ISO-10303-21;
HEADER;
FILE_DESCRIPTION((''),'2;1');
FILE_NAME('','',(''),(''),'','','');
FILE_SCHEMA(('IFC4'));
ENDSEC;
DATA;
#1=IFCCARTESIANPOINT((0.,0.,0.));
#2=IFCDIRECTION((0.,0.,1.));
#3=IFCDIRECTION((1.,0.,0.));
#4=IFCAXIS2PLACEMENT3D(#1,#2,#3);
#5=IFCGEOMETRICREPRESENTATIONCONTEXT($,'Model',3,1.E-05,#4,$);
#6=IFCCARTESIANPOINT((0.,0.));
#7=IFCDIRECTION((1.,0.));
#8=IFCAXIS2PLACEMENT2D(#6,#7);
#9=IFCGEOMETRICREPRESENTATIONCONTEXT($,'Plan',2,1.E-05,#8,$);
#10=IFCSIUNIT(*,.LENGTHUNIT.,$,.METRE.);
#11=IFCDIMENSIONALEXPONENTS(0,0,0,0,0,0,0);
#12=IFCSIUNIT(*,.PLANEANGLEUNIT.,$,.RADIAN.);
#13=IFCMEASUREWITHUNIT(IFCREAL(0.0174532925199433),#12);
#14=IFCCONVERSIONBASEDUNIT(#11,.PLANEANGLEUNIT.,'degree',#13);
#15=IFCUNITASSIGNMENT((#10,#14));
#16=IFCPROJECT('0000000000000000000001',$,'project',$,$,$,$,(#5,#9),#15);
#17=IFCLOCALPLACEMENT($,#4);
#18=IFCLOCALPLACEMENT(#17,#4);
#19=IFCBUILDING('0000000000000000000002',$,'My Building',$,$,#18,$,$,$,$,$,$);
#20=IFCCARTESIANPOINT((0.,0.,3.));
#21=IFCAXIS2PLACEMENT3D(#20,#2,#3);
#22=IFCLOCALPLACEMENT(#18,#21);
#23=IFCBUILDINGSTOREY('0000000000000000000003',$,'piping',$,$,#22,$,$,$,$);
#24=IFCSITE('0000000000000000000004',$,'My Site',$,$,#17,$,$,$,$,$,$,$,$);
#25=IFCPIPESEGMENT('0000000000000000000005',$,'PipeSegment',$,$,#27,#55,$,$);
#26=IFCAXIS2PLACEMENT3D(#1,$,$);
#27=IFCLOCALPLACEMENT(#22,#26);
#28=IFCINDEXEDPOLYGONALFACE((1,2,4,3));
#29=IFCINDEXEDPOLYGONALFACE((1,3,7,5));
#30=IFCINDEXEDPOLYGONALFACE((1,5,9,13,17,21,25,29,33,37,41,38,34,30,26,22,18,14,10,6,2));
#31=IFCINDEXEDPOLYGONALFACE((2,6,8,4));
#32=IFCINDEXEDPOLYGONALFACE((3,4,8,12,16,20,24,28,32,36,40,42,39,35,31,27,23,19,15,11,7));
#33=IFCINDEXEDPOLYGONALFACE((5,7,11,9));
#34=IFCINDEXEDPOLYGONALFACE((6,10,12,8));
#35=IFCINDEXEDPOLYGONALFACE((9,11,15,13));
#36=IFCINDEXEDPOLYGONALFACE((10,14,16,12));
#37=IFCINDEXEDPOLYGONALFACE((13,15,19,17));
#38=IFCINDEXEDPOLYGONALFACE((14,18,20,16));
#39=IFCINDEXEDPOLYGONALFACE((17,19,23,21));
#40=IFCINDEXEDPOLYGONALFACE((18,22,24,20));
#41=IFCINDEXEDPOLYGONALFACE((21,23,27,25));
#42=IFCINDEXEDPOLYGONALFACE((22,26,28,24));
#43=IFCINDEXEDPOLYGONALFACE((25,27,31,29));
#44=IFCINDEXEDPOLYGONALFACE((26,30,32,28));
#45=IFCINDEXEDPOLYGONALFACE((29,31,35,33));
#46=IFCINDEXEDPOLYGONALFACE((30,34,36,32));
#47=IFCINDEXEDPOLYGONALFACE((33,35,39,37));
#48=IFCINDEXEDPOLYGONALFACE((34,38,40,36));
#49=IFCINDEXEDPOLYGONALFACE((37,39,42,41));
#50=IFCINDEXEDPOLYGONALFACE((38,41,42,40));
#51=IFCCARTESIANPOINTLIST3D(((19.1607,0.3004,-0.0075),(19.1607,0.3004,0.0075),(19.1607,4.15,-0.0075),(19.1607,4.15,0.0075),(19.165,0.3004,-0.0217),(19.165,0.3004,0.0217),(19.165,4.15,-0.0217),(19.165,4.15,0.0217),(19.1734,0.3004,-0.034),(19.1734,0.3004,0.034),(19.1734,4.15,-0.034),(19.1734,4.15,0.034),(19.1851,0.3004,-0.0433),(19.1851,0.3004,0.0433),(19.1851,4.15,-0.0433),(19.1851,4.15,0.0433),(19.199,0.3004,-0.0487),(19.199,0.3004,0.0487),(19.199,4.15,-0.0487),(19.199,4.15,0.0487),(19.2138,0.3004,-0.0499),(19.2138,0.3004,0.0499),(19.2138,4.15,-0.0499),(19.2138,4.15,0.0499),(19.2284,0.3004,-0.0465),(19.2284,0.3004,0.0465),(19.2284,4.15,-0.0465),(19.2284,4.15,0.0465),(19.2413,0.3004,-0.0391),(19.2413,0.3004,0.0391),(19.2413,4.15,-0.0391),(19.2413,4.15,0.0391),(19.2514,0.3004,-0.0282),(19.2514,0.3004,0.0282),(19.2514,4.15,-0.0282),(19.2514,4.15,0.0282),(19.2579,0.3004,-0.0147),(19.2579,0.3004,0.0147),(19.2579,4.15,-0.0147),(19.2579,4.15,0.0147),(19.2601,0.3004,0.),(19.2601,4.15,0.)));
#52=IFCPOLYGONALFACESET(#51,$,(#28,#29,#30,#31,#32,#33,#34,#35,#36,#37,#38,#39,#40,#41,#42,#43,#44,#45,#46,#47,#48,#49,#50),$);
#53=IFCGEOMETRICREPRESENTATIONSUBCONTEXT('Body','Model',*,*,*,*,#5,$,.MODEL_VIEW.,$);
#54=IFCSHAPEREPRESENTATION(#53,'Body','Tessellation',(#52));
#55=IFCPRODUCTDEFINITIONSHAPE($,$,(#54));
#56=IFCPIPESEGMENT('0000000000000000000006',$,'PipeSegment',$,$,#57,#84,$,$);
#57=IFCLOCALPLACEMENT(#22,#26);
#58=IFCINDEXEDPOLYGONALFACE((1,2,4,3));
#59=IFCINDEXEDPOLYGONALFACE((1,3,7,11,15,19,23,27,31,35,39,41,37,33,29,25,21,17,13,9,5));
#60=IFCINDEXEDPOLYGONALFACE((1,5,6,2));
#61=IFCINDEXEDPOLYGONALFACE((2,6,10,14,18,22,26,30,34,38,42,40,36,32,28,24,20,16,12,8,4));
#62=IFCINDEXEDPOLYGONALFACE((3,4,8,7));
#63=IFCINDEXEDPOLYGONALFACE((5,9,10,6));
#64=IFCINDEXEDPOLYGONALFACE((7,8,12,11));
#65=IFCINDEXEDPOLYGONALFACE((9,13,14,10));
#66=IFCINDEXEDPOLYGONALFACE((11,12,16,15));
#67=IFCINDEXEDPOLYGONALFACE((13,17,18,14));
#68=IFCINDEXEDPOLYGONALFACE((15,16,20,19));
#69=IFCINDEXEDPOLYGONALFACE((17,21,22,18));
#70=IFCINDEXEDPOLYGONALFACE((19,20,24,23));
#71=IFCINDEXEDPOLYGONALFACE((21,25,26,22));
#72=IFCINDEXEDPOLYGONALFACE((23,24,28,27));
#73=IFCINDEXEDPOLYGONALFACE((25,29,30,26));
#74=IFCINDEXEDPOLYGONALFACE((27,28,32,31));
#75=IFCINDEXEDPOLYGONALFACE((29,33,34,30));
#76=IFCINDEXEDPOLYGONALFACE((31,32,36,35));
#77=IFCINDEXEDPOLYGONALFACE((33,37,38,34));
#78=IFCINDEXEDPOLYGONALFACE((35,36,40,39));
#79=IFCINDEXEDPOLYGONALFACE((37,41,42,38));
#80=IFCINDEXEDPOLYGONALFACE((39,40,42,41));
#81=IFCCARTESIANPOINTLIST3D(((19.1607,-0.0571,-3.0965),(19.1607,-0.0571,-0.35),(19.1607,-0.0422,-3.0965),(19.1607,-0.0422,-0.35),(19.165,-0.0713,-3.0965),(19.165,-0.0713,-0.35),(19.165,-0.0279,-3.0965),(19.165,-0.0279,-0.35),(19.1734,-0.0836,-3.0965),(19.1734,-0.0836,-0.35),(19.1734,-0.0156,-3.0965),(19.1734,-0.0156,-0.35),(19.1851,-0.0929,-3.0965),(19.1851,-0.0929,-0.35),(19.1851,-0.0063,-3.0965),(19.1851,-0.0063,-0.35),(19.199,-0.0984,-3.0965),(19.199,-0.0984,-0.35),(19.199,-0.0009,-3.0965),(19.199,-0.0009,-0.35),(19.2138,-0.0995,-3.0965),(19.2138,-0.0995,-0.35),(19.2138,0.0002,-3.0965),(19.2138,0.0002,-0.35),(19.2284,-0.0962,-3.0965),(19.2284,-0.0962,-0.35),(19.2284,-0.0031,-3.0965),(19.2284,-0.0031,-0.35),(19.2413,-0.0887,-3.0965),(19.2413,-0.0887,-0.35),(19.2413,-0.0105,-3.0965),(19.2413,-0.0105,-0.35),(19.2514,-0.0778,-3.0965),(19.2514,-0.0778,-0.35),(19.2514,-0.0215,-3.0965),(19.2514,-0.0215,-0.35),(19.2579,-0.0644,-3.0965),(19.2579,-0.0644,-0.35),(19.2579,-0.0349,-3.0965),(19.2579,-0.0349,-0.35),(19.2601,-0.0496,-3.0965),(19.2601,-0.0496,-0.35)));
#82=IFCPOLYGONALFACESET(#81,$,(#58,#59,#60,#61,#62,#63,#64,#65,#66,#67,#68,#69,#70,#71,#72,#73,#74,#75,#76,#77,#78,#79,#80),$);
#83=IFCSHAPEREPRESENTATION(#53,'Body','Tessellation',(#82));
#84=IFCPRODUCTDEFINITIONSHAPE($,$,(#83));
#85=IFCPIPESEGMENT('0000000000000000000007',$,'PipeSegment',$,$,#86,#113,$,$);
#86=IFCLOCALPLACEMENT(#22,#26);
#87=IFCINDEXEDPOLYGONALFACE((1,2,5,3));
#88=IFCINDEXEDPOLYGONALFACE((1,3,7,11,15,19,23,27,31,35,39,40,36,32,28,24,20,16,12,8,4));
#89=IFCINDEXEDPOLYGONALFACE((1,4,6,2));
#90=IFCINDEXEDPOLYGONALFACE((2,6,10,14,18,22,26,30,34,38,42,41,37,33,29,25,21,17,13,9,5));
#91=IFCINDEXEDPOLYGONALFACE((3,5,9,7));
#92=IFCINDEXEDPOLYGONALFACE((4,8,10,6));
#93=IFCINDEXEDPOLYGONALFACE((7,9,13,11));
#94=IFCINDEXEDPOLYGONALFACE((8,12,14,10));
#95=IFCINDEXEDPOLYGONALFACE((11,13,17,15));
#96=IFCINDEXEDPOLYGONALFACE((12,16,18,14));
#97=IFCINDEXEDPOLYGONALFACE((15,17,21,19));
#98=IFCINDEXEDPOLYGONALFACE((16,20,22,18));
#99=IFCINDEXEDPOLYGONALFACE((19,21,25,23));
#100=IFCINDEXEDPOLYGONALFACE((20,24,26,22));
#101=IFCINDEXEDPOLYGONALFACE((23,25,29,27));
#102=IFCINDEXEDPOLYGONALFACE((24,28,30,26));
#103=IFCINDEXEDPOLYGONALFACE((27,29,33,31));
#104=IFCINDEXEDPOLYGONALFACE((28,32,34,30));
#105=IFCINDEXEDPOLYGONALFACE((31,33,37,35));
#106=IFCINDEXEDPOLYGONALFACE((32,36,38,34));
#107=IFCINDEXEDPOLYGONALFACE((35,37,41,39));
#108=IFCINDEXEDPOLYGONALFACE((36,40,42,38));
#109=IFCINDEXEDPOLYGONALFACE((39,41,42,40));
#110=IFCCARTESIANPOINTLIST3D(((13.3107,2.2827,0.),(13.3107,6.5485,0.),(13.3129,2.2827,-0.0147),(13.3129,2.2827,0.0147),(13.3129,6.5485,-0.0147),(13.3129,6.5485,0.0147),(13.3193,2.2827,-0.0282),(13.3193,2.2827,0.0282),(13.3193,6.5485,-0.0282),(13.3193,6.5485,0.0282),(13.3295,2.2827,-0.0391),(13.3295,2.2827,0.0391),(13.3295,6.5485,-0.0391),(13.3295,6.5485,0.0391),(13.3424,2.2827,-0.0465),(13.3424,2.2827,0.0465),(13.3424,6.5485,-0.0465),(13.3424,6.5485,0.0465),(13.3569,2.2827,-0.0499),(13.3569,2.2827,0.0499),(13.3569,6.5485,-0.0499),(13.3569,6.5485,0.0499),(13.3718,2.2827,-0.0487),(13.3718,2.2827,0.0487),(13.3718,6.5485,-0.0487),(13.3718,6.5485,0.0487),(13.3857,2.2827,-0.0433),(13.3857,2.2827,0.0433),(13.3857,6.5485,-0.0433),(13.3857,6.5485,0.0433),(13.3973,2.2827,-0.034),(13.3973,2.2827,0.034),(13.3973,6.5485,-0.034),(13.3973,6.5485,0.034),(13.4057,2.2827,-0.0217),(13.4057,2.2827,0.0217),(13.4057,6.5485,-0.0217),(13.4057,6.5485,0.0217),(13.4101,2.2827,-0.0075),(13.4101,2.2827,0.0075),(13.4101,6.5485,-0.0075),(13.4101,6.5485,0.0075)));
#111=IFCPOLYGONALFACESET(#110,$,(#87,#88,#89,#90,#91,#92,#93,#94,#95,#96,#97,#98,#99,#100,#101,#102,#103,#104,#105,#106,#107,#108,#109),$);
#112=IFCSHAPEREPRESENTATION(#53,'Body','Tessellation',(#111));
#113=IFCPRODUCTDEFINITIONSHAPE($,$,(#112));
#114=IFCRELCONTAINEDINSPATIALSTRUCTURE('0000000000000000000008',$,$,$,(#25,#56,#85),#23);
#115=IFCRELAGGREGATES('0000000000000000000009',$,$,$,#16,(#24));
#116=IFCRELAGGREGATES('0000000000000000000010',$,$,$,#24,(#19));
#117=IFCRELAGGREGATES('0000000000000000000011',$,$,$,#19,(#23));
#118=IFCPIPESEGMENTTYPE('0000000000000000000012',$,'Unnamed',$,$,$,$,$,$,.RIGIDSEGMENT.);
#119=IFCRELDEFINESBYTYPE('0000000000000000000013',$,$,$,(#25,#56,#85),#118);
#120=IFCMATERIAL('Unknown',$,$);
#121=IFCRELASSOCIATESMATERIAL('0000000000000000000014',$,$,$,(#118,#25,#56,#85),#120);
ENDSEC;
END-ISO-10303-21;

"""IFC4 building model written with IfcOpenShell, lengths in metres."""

from ifc_helpers import new_model, entity, si_unit, converted_unit, frame, origin_with_axes, origin_2d_with_axis, place, context, subcontext, project, spatial, circle, extrude, material, material_profile, profile_set, profile_usage, type_object, element, save


model = new_model("IFC4")

# Units and contexts
model_context = context("Model", 3, precision=1e-05, world=origin_with_axes())
plan_context = context("Plan", 2, precision=1e-05, world=origin_2d_with_axis())
body_context = subcontext(model_context, "Body", "Model", "MODEL_VIEW")
ifc_project = project(units=[si_unit("LENGTHUNIT", "METRE"), converted_unit("PLANEANGLEUNIT", "degree", entity("IfcReal", 0.0174532925199433), si_unit("PLANEANGLEUNIT", "RADIAN"), dimensions=[0, 0, 0, 0, 0, 0, 0])], contexts=[model_context, plan_context])

# Site, building, storey
site_placement = place(None, origin_with_axes())
site = spatial("IfcSite", under=ifc_project, at=site_placement, Name="My Site")
building_placement = place(site_placement, origin_with_axes())
building = spatial("IfcBuilding", under=site, at=building_placement, Name="My Building")
storey_placement = place(building_placement, frame((0.0, 0.0, 3.0), z_axis=(0.0, 0.0, 1.0), x_axis=(1.0, 0.0, 0.0)))
storey = spatial("IfcBuildingStorey", under=building, at=storey_placement, Name="piping")

# Pipe segments
ifc_material = material(Name="Unknown")
ifc_material_profile = material_profile(ifc_material, circle(Radius=0.05))
ifc_profile_set = profile_set([ifc_material_profile])
pipe_segment_type = type_object("IfcPipeSegmentType", Name="Unnamed", PredefinedType="RIGIDSEGMENT", material=ifc_profile_set)
ifc_profile_usage_1 = profile_usage(ifc_profile_set, cardinal=5)
pipe_segment_1_placement = place(storey_placement, frame((19.2101, 4.15, 0.0), z_axis=(0.0, -1.0, 0.0), x_axis=(1.0, 0.0, 0.0)))
element("IfcPipeSegment", 1, at=pipe_segment_1_placement, inside=storey, type_object=pipe_segment_type, material=ifc_profile_usage_1, Name="PipeSegment", context=body_context, shape_type="SweptSolid", body=[
    extrude(circle(Radius=0.05), origin_with_axes(), (0.0, 0.0, 1.0), 3.8496),
])
ifc_profile_usage_2 = profile_usage(ifc_profile_set, cardinal=5)
pipe_segment_2_placement = place(storey_placement, frame((19.2101, -0.0496, -0.35), z_axis=(0.0, 0.0, -1.0), x_axis=(1.0, 0.0, 0.0)))
element("IfcPipeSegment", 2, at=pipe_segment_2_placement, inside=storey, type_object=pipe_segment_type, material=ifc_profile_usage_2, Name="PipeSegment", context=body_context, shape_type="SweptSolid", body=[
    extrude(circle(Radius=0.05), origin_with_axes(), (0.0, 0.0, 1.0), 2.7465),
])
ifc_profile_usage_3 = profile_usage(ifc_profile_set, cardinal=5)
pipe_segment_3_placement = place(storey_placement, frame((13.3607, 2.2827, 0.0), z_axis=(0.0, 1.0, 0.0), x_axis=(-1.0, 0.0, 0.0)))
element("IfcPipeSegment", 3, at=pipe_segment_3_placement, inside=storey, type_object=pipe_segment_type, material=ifc_profile_usage_3, Name="PipeSegment", context=body_context, shape_type="SweptSolid", body=[
    extrude(circle(Radius=0.05), origin_with_axes(), (0.0, 0.0, 1.0), 4.2658),
])

save(model, "model.ifc")
